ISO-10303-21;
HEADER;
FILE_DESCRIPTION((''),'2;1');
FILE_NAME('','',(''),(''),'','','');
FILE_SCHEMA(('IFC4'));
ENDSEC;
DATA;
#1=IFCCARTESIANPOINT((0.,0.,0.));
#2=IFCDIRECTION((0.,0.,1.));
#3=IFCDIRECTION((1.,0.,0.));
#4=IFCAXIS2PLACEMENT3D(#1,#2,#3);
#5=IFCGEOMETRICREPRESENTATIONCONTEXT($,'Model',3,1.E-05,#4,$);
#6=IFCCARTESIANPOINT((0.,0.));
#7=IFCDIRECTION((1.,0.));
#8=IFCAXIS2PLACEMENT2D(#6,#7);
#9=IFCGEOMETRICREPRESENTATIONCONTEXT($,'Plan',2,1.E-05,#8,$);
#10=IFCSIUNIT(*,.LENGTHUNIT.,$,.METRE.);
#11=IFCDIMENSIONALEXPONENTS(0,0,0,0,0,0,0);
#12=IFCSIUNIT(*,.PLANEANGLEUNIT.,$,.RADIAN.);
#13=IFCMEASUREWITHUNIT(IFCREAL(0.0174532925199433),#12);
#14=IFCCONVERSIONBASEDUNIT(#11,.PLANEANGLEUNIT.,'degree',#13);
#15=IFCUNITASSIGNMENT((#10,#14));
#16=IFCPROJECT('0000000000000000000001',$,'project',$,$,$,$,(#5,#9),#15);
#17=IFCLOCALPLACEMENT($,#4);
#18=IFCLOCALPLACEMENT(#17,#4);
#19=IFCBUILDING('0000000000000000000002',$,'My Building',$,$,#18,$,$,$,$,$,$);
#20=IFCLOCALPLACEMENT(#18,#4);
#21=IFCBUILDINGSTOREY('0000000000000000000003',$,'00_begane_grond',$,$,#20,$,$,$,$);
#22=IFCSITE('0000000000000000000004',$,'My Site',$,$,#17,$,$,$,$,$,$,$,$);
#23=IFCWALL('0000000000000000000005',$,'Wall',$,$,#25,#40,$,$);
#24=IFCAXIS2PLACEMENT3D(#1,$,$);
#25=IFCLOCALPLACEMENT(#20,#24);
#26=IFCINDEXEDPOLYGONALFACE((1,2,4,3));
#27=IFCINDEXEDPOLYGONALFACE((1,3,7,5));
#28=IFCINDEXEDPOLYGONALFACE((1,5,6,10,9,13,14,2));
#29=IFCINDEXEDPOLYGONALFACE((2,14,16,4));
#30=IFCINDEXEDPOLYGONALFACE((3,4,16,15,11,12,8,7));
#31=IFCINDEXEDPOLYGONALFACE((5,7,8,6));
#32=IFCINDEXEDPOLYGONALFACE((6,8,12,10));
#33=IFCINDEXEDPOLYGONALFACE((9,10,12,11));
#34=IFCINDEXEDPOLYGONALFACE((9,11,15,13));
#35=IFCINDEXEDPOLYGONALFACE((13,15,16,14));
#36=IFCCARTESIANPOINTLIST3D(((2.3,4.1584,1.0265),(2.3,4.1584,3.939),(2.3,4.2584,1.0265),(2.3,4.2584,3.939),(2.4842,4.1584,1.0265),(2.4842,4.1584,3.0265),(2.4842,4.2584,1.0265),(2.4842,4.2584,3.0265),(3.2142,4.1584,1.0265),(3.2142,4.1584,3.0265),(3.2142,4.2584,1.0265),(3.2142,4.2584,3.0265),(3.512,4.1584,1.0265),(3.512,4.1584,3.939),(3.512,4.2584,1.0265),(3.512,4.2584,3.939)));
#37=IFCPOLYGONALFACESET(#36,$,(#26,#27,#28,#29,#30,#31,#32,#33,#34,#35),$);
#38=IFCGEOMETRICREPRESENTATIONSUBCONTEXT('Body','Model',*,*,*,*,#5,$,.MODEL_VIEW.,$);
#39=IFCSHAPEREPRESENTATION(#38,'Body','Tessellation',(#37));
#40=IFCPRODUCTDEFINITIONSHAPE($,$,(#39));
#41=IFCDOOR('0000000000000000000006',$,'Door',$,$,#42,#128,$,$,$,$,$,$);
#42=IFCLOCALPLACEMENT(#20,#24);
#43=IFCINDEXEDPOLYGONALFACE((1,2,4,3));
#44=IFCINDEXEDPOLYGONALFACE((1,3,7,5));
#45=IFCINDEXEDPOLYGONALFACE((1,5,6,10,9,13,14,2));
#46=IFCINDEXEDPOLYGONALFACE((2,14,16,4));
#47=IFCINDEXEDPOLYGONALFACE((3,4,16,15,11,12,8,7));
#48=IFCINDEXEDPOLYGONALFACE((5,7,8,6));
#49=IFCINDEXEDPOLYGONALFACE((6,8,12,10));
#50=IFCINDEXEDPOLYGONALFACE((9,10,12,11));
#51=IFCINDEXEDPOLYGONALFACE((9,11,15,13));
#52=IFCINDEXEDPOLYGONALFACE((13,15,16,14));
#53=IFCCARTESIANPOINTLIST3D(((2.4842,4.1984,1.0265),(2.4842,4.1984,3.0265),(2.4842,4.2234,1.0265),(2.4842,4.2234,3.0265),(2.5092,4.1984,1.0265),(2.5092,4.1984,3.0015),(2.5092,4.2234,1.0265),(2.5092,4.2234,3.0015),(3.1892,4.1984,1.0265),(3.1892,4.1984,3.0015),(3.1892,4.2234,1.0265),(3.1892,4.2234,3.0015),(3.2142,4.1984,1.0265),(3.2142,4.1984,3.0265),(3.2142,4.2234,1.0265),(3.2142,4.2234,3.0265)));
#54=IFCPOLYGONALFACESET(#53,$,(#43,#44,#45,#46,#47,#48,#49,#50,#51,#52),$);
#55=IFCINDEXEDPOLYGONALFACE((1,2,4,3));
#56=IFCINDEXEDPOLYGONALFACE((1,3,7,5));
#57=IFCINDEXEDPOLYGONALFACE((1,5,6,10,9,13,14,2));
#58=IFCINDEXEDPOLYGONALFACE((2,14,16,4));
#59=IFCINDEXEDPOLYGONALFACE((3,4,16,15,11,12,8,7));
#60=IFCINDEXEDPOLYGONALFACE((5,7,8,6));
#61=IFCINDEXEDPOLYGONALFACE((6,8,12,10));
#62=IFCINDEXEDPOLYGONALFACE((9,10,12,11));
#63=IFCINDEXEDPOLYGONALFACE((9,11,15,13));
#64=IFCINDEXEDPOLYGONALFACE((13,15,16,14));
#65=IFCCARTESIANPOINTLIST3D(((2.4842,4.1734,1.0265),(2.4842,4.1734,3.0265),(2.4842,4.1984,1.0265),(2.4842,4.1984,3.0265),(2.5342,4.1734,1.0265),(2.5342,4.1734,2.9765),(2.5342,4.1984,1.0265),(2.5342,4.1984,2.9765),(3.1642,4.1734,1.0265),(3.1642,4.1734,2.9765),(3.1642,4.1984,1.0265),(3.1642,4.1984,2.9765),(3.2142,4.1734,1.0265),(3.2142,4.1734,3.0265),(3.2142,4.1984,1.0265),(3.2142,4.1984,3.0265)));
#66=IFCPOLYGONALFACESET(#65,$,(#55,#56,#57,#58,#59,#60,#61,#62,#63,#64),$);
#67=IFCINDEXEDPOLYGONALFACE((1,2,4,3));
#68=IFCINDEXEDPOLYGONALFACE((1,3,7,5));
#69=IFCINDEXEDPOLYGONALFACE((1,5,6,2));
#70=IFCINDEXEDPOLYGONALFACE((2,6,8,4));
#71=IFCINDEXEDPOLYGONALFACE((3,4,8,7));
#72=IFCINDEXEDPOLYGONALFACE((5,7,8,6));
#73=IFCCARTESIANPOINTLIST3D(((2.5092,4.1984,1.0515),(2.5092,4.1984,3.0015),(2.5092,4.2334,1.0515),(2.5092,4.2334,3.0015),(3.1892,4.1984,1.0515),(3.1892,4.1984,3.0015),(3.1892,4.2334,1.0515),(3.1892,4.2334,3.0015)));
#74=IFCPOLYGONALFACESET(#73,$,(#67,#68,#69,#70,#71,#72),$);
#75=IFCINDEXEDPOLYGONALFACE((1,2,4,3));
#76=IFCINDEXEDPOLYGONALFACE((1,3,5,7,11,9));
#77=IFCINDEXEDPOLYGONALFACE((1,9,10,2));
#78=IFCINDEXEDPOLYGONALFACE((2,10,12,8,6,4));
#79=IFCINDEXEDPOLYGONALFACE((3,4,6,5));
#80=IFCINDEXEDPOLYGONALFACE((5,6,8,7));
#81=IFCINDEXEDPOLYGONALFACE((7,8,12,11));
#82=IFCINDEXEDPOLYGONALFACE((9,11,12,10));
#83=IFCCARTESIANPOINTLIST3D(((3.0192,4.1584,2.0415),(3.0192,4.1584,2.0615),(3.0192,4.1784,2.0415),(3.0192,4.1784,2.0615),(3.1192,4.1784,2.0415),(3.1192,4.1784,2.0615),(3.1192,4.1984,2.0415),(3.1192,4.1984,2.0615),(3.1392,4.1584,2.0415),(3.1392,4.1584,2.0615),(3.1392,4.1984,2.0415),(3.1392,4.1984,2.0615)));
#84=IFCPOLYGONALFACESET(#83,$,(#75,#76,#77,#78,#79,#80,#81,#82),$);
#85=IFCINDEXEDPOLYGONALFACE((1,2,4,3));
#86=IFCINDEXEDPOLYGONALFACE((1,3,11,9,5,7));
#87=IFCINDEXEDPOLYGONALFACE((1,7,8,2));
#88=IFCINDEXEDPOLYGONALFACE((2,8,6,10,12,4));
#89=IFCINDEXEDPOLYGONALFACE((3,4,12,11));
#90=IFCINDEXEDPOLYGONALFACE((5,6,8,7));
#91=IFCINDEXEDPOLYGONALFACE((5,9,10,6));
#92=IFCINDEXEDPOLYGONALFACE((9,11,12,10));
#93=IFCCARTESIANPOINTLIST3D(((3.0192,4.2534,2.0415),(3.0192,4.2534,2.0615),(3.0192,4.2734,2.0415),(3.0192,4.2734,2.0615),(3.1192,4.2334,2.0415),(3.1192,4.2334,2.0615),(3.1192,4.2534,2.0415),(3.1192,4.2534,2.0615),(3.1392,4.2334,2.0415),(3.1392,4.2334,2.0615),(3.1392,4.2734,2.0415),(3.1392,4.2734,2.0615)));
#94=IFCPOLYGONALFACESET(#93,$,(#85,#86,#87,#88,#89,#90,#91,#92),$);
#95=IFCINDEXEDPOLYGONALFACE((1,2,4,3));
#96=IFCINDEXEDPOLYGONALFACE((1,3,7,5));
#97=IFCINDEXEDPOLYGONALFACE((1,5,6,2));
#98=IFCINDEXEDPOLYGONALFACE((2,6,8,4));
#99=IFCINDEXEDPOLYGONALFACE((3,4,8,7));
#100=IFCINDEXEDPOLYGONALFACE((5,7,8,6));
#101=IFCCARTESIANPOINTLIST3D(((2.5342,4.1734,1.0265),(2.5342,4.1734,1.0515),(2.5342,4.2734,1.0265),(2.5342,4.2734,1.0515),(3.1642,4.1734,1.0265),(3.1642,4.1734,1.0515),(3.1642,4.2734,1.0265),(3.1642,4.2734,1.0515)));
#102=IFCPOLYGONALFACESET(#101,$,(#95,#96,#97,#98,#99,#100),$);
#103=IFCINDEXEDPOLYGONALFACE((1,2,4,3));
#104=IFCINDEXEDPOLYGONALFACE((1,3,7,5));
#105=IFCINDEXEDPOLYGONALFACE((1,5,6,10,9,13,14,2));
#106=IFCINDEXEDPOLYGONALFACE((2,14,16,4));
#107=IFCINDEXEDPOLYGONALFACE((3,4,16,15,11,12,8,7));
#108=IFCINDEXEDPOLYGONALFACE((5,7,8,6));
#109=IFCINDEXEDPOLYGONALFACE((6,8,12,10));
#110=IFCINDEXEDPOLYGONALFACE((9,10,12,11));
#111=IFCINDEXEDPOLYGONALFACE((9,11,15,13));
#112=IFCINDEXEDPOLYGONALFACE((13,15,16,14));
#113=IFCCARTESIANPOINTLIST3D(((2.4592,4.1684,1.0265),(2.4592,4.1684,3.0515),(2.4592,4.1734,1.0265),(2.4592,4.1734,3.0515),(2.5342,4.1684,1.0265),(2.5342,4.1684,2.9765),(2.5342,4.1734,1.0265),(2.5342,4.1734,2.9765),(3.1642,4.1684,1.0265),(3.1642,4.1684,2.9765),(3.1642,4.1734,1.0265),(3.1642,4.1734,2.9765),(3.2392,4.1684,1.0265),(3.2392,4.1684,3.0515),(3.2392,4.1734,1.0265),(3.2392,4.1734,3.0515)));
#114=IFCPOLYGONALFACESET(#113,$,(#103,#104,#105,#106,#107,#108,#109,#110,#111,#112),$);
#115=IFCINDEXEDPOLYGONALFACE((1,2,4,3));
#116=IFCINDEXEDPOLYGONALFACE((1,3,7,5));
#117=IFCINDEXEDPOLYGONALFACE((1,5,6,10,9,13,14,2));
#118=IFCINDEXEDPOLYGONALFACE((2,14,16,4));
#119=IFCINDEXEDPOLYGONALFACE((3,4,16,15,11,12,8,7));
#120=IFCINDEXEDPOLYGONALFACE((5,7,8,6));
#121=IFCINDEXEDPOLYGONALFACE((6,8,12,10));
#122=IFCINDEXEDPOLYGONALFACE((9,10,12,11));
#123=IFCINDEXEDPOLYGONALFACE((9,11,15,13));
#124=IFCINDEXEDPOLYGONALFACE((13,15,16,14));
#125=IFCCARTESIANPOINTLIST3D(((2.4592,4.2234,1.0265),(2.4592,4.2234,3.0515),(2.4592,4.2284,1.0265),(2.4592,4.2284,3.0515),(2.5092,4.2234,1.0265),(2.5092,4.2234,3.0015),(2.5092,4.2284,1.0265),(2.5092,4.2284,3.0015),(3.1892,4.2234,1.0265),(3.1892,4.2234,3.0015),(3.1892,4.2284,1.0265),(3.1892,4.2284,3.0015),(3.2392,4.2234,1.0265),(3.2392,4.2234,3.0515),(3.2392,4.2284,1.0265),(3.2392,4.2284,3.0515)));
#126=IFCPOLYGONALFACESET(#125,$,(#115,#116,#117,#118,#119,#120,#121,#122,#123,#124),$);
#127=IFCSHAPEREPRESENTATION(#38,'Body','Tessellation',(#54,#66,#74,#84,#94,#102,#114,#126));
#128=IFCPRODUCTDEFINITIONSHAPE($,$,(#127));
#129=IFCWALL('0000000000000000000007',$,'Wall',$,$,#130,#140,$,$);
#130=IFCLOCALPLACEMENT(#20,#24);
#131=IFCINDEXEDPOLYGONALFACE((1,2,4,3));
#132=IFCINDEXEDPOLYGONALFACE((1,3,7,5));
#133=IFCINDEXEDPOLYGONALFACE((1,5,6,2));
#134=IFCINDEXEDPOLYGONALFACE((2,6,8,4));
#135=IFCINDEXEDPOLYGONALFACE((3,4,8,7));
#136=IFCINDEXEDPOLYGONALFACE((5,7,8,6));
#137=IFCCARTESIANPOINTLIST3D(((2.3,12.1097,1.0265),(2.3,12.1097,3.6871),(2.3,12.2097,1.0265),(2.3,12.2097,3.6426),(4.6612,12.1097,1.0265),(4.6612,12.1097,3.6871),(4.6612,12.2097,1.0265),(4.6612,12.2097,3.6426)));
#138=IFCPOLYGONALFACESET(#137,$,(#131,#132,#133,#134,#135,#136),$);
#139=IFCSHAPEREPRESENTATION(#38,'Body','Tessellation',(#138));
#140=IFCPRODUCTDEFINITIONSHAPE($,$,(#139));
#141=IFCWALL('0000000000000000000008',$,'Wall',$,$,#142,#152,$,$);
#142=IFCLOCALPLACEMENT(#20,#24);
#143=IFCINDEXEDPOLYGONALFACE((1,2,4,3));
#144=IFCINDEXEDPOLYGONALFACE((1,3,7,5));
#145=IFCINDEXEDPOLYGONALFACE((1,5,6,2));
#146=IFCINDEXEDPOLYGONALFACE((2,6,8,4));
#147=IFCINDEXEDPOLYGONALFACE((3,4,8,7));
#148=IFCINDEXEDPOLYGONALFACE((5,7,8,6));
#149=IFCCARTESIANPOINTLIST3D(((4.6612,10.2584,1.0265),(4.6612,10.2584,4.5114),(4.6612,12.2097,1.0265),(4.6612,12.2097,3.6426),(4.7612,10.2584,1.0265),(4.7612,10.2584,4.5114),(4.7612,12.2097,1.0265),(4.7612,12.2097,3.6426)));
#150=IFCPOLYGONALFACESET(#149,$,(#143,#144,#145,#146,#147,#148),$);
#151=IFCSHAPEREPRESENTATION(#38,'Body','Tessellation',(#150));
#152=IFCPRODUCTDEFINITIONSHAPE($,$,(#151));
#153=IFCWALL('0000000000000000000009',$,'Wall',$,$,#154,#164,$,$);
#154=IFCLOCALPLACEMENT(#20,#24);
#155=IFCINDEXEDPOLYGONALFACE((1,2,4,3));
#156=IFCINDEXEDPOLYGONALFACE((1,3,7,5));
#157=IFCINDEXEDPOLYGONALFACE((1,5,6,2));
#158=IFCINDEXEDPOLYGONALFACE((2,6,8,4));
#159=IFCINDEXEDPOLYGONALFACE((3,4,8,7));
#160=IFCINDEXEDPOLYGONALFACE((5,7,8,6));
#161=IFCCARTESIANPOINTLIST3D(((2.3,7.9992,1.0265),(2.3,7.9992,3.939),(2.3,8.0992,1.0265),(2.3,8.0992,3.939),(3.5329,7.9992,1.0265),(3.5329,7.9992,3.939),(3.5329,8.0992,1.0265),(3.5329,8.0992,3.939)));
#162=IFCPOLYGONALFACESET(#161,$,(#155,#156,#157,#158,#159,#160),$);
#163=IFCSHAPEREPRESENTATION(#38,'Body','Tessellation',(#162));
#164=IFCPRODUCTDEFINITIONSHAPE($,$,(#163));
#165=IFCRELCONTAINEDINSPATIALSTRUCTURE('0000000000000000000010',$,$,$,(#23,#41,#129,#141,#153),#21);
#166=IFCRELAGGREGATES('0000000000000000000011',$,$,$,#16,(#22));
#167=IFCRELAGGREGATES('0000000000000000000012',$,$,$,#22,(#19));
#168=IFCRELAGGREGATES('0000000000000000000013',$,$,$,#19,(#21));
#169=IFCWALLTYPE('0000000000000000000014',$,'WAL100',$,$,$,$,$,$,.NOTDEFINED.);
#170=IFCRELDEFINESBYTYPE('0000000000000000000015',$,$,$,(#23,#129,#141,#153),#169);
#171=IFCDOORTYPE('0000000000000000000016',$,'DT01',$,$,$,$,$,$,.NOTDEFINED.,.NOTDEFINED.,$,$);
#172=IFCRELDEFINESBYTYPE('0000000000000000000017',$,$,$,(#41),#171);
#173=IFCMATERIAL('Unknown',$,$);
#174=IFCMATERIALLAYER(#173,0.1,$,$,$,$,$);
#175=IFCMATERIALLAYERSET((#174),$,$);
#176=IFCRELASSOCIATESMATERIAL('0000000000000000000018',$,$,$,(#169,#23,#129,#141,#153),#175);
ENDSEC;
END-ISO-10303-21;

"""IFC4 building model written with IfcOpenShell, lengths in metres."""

from ifc_helpers import new_model, entity, si_unit, converted_unit, frame, origin_with_axes, origin_2d_with_axis, place, context, subcontext, project, spatial, line, indexed_curve, outline, extrude, clip, halfspace, shape, source, transform, mapped, material, layer, layer_set, layer_usage, type_object, type_shapes, element, fill, save


model = new_model("IFC4")

# Units and contexts
model_context = context("Model", 3, precision=1e-05, world=origin_with_axes())
plan_context = context("Plan", 2, precision=1e-05, world=origin_2d_with_axis())
body_context_1 = subcontext(model_context, "Body", "Model", "MODEL_VIEW")
body_context_2 = subcontext(plan_context, "Body", "Plan", "PLAN_VIEW")
ifc_project = project(units=[si_unit("LENGTHUNIT", "METRE"), converted_unit("PLANEANGLEUNIT", "degree", entity("IfcReal", 0.0174532925199433), si_unit("PLANEANGLEUNIT", "RADIAN"), dimensions=[0, 0, 0, 0, 0, 0, 0])], contexts=[model_context, plan_context])

# Site, building, storey
site_placement = place(None, origin_with_axes())
site = spatial("IfcSite", under=ifc_project, at=site_placement, Name="My Site")
building_placement = place(site_placement, origin_with_axes())
building = spatial("IfcBuilding", under=site, at=building_placement, Name="My Building")
storey_placement = place(building_placement, origin_with_axes())
storey = spatial("IfcBuildingStorey", under=building, at=storey_placement, Name="00_begane_grond")

# Shared definitions
ifc_material = material(Name="Unknown")

# Shared definitions
ifc_layer_1 = layer(ifc_material, 0.1)
ifc_layer_set_1 = layer_set([ifc_layer_1])
wall_type_1 = type_object("IfcWallType", Name="WAL100", PredefinedType="NOTDEFINED", material=ifc_layer_set_1)

# Wall, opening, door
ifc_layer_usage_1 = layer_usage(ifc_layer_set_1, "AXIS2", "POSITIVE", 0.0)
wall_1_placement = place(storey_placement, frame((3.512, 4.2584, 1.0265), z_axis=(0.0, 0.0, 1.0), x_axis=(-1.0, 0.0, 0.0)))
wall_1 = element("IfcWall", 1, at=wall_1_placement, inside=storey, type_object=wall_type_1, material=ifc_layer_usage_1, Name="Wall", context=body_context_1, shape_type="Clipping", body=[
    clip(extrude(outline(indexed_curve([(0.0, 0.0), (0.0, 0.1), (1.212, 0.1), (1.212, 0.0), (0.0, 0.0)], self_intersect=False)), origin_with_axes(), (0.0, 0.0, 1.0), 3.939), halfspace(frame((0.0, 0.0, 2.9125), z_axis=(0.0, 0.0, 1.0), x_axis=(-1.0, 0.0, 0.0)), False)),
])
shared_shape_1 = source(origin_with_axes(), body_context_1, "Body", "SweptSolid", [
    extrude(outline(indexed_curve([(0.0, 0.0), (0.73, 0.0), (0.73, 2.0), (0.0, 2.0)], segments=[line(1, 2, 3, 4, 1)])), frame((0.0, -0.1, 0.0), z_axis=(0.0, -1.0, 0.0), x_axis=(1.0, 0.0, 0.0)), (0.0, 0.0, -1.0), 0.3),
])
opening_1_placement = place(wall_1_placement, frame((0.2978, 0.0, 0.0), z_axis=(0.0, 0.0, 1.0), x_axis=(1.0, 0.0, 0.0)))
opening_1 = element("IfcOpeningElement", 2, at=opening_1_placement, cuts=wall_1, PredefinedType="OPENING", context=body_context_1, shape_type="MappedRepresentation", body=[
    mapped(shared_shape_1, transform((0.0, 0.0, 0.0), x_axis=(1.0, 0.0, 0.0), y_axis=(0.0, 1.0, 0.0), z_axis=(0.0, 0.0, 1.0), scale=1.0)),
])
door_type_1 = type_object("IfcDoorType", Name="DT01", OperationType="NOTDEFINED", PredefinedType="NOTDEFINED")
shared_shape_2 = source(origin_with_axes(), body_context_1, "Body", "SweptSolid", [
    extrude(outline(indexed_curve([(0.0, 0.0), (0.0, 2.0), (0.73, 2.0), (0.73, 0.0), (0.705, 0.0), (0.705, 1.975), (0.025, 1.975), (0.025, 0.0)], segments=[line(1, 2, 3, 4, 5, 6, 7, 8, 1)])), frame((0.0, 0.025, 0.0), z_axis=(0.0, -1.0, 0.0), x_axis=(1.0, 0.0, 0.0)), (0.0, 0.0, -1.0), 0.025),
    extrude(outline(indexed_curve([(0.0, 0.0), (0.0, 2.0), (0.73, 2.0), (0.73, 0.0), (0.68, 0.0), (0.68, 1.95), (0.05, 1.95), (0.05, 0.0)], segments=[line(1, 2, 3, 4, 5, 6, 7, 8, 1)])), frame((0.0, 0.0, 0.0), z_axis=(0.0, -1.0, 0.0), x_axis=(1.0, 0.0, 0.0)), (0.0, 0.0, -1.0), 0.025),
    extrude(outline(indexed_curve([(0.0, 0.0), (0.68, 0.0), (0.68, 0.035), (0.0, 0.035)], segments=[line(1, 2, 3, 4, 1)])), frame((0.025, 0.025, 0.025), z_axis=(0.0, 0.0, 1.0), x_axis=(1.0, 0.0, 0.0)), (0.0, 0.0, 1.0), 1.95),
    extrude(outline(indexed_curve([(0.0, 0.0), (0.0, -0.04), (-0.12, -0.04), (-0.12, -0.02), (-0.02, -0.02), (-0.02, 0.0)], segments=[line(1, 2, 3, 4, 5, 6, 1)])), frame((0.655, 0.025, 1.015), z_axis=(0.0, 0.0, 1.0), x_axis=(1.0, 0.0, 0.0)), (0.0, 0.0, 1.0), 0.02),
    extrude(outline(indexed_curve([(0.0, 0.0), (0.0, 0.04), (-0.12, 0.04), (-0.12, 0.02), (-0.02, 0.02), (-0.02, 0.0)], segments=[line(1, 2, 3, 4, 5, 6, 1)])), frame((0.655, 0.06, 1.015), z_axis=(0.0, 0.0, 1.0), x_axis=(1.0, 0.0, 0.0)), (0.0, 0.0, 1.0), 0.02),
    extrude(outline(indexed_curve([(0.0, 0.0), (0.63, 0.0), (0.63, 0.1), (0.0, 0.1)], segments=[line(1, 2, 3, 4, 1)])), frame((0.05, 0.0, 0.0), z_axis=(0.0, 0.0, 1.0), x_axis=(1.0, 0.0, 0.0)), (0.0, 0.0, 1.0), 0.025),
    extrude(outline(indexed_curve([(0.0, 0.0), (0.0, 2.025), (0.78, 2.025), (0.78, 0.0), (0.705, 0.0), (0.705, 1.95), (0.075, 1.95), (0.075, 0.0)], segments=[line(1, 2, 3, 4, 5, 6, 7, 8, 1)])), frame((-0.025, -0.005, 0.0), z_axis=(0.0, -1.0, 0.0), x_axis=(1.0, 0.0, 0.0)), (0.0, 0.0, -1.0), 0.005),
    extrude(outline(indexed_curve([(0.0, 0.0), (0.0, 2.025), (0.78, 2.025), (0.78, 0.0), (0.73, 0.0), (0.73, 1.975), (0.05, 1.975), (0.05, 0.0)], segments=[line(1, 2, 3, 4, 5, 6, 7, 8, 1)])), frame((-0.025, 0.05, 0.0), z_axis=(0.0, -1.0, 0.0), x_axis=(1.0, 0.0, 0.0)), (0.0, 0.0, -1.0), 0.005),
])
shared_shape_3 = source(origin_with_axes(), body_context_2, "Body", "Curve2D", [
    entity("IfcIndexedPolyCurve", entity("IfcCartesianPointList2D", [[0.0, 0.0], [0.0, 0.05], [0.025, 0.05], [0.025, 0.025], [0.05, 0.025], [0.05, 0.0]]), [entity("IfcLineIndex", [1, 2, 3, 4, 5, 6, 1])]),
    entity("IfcIndexedPolyCurve", entity("IfcCartesianPointList2D", [[0.73, 0.0], [0.73, 0.05], [0.705, 0.05], [0.705, 0.025], [0.68, 0.025], [0.68, 0.0]]), [entity("IfcLineIndex", [1, 2, 3, 4, 5, 6, 1])]),
    entity("IfcTrimmedCurve", entity("IfcEllipse", entity("IfcAxis2Placement2D", entity("IfcCartesianPoint", [0.06, 0.05]), entity("IfcDirection", [1.0, 0.0])), 0.645, 0.68), [entity("IfcCartesianPoint", [0.705, 0.05])], [entity("IfcCartesianPoint", [0.06, 0.73])], True, "CARTESIAN"),
    entity("IfcIndexedPolyCurve", entity("IfcCartesianPointList2D", [[0.025, 0.05], [0.06, 0.05], [0.06, 0.73], [0.025, 0.73]]), [entity("IfcLineIndex", [1, 2, 3, 4, 1])]),
])
type_shapes(door_type_1, [shared_shape_2, shared_shape_3])
door_1_placement = place(opening_1_placement, frame((0.73, 0.085, 0.0), z_axis=(0.0, 0.0, 1.0), x_axis=(-1.0, 0.0, 0.0)))
door_1 = element("IfcDoor", 3, at=door_1_placement, inside=storey, type_object=door_type_1, Name="Door", shapes=[
    shape(body_context_1, "Body", "MappedRepresentation", [mapped(shared_shape_2, transform((0.0, 0.0, 0.0), x_axis=(1.0, 0.0, 0.0), y_axis=(0.0, 1.0, 0.0), z_axis=(0.0, 0.0, 1.0), scale=1.0))]),
    shape(body_context_2, "Body", "MappedRepresentation", [mapped(shared_shape_3, transform((0.0, 0.0, 0.0), x_axis=(1.0, 0.0, 0.0), y_axis=(0.0, 1.0, 0.0), z_axis=(0.0, 0.0, 1.0), scale=1.0))]),
])
fill(opening_1, door_1)

# Walls
ifc_layer_usage_2 = layer_usage(ifc_layer_set_1, "AXIS2", "POSITIVE", 0.0)
wall_2_placement = place(storey_placement, frame((2.3, 12.1097, 1.0265), z_axis=(0.0, 0.0, 1.0), x_axis=(1.0, -0.000001, 0.0)))
element("IfcWall", 4, at=wall_2_placement, inside=storey, type_object=wall_type_1, material=ifc_layer_usage_2, Name="Wall", context=body_context_1, shape_type="Clipping", body=[
    clip(extrude(outline(indexed_curve([(0.0, 0.0), (0.0, 0.1), (2.3611, 0.1), (2.3611, 0.0), (0.0, 0.0)], self_intersect=False)), origin_with_axes(), (0.0, 0.0, 1.0), 3.6871), halfspace(frame((2.3611, 0.0, 2.6606), z_axis=(0.0, 0.406737, 0.913545), x_axis=(1.0, 0.000001, 0.0)), False)),
])
ifc_layer_usage_3 = layer_usage(ifc_layer_set_1, "AXIS2", "POSITIVE", 0.0)
wall_3_placement = place(storey_placement, frame((4.6612, 12.2097, 1.0265), z_axis=(0.0, 0.0, 1.0), x_axis=(-0.000001, -1.0, 0.0)))
element("IfcWall", 5, at=wall_3_placement, inside=storey, type_object=wall_type_1, material=ifc_layer_usage_3, Name="Wall", context=body_context_1, shape_type="Clipping", body=[
    clip(extrude(outline(indexed_curve([(0.0, 0.0), (0.0, 0.1), (1.9513, 0.1), (1.9513, 0.0), (0.0, 0.0)], self_intersect=False)), origin_with_axes(), (0.0, 0.0, 1.0), 4.6121), halfspace(frame((2.1775, 0.0, 3.5855), z_axis=(-0.406737, 0.0, 0.913545), x_axis=(-0.000001, 1.0, 0.0)), False)),
])
ifc_layer_usage_4 = layer_usage(ifc_layer_set_1, "AXIS2", "POSITIVE", 0.0)
wall_4_placement = place(storey_placement, frame((2.3, 7.9992, 1.0265), z_axis=(0.0, 0.0, 1.0), x_axis=(1.0, -0.000001, 0.0)))
element("IfcWall", 6, at=wall_4_placement, inside=storey, type_object=wall_type_1, material=ifc_layer_usage_4, Name="Wall", context=body_context_1, shape_type="Clipping", body=[
    clip(extrude(outline(indexed_curve([(0.0, 0.0), (0.0, 0.1), (1.2329, 0.1), (1.2329, 0.0), (0.0, 0.0)], self_intersect=False)), origin_with_axes(), (0.0, 0.0, 1.0), 3.939), halfspace(frame((0.0, 0.0, 2.9125), z_axis=(0.0, 0.0, 1.0), x_axis=(-1.0, 0.0, 0.0)), False)),
])

save(model, "model.ifc")
